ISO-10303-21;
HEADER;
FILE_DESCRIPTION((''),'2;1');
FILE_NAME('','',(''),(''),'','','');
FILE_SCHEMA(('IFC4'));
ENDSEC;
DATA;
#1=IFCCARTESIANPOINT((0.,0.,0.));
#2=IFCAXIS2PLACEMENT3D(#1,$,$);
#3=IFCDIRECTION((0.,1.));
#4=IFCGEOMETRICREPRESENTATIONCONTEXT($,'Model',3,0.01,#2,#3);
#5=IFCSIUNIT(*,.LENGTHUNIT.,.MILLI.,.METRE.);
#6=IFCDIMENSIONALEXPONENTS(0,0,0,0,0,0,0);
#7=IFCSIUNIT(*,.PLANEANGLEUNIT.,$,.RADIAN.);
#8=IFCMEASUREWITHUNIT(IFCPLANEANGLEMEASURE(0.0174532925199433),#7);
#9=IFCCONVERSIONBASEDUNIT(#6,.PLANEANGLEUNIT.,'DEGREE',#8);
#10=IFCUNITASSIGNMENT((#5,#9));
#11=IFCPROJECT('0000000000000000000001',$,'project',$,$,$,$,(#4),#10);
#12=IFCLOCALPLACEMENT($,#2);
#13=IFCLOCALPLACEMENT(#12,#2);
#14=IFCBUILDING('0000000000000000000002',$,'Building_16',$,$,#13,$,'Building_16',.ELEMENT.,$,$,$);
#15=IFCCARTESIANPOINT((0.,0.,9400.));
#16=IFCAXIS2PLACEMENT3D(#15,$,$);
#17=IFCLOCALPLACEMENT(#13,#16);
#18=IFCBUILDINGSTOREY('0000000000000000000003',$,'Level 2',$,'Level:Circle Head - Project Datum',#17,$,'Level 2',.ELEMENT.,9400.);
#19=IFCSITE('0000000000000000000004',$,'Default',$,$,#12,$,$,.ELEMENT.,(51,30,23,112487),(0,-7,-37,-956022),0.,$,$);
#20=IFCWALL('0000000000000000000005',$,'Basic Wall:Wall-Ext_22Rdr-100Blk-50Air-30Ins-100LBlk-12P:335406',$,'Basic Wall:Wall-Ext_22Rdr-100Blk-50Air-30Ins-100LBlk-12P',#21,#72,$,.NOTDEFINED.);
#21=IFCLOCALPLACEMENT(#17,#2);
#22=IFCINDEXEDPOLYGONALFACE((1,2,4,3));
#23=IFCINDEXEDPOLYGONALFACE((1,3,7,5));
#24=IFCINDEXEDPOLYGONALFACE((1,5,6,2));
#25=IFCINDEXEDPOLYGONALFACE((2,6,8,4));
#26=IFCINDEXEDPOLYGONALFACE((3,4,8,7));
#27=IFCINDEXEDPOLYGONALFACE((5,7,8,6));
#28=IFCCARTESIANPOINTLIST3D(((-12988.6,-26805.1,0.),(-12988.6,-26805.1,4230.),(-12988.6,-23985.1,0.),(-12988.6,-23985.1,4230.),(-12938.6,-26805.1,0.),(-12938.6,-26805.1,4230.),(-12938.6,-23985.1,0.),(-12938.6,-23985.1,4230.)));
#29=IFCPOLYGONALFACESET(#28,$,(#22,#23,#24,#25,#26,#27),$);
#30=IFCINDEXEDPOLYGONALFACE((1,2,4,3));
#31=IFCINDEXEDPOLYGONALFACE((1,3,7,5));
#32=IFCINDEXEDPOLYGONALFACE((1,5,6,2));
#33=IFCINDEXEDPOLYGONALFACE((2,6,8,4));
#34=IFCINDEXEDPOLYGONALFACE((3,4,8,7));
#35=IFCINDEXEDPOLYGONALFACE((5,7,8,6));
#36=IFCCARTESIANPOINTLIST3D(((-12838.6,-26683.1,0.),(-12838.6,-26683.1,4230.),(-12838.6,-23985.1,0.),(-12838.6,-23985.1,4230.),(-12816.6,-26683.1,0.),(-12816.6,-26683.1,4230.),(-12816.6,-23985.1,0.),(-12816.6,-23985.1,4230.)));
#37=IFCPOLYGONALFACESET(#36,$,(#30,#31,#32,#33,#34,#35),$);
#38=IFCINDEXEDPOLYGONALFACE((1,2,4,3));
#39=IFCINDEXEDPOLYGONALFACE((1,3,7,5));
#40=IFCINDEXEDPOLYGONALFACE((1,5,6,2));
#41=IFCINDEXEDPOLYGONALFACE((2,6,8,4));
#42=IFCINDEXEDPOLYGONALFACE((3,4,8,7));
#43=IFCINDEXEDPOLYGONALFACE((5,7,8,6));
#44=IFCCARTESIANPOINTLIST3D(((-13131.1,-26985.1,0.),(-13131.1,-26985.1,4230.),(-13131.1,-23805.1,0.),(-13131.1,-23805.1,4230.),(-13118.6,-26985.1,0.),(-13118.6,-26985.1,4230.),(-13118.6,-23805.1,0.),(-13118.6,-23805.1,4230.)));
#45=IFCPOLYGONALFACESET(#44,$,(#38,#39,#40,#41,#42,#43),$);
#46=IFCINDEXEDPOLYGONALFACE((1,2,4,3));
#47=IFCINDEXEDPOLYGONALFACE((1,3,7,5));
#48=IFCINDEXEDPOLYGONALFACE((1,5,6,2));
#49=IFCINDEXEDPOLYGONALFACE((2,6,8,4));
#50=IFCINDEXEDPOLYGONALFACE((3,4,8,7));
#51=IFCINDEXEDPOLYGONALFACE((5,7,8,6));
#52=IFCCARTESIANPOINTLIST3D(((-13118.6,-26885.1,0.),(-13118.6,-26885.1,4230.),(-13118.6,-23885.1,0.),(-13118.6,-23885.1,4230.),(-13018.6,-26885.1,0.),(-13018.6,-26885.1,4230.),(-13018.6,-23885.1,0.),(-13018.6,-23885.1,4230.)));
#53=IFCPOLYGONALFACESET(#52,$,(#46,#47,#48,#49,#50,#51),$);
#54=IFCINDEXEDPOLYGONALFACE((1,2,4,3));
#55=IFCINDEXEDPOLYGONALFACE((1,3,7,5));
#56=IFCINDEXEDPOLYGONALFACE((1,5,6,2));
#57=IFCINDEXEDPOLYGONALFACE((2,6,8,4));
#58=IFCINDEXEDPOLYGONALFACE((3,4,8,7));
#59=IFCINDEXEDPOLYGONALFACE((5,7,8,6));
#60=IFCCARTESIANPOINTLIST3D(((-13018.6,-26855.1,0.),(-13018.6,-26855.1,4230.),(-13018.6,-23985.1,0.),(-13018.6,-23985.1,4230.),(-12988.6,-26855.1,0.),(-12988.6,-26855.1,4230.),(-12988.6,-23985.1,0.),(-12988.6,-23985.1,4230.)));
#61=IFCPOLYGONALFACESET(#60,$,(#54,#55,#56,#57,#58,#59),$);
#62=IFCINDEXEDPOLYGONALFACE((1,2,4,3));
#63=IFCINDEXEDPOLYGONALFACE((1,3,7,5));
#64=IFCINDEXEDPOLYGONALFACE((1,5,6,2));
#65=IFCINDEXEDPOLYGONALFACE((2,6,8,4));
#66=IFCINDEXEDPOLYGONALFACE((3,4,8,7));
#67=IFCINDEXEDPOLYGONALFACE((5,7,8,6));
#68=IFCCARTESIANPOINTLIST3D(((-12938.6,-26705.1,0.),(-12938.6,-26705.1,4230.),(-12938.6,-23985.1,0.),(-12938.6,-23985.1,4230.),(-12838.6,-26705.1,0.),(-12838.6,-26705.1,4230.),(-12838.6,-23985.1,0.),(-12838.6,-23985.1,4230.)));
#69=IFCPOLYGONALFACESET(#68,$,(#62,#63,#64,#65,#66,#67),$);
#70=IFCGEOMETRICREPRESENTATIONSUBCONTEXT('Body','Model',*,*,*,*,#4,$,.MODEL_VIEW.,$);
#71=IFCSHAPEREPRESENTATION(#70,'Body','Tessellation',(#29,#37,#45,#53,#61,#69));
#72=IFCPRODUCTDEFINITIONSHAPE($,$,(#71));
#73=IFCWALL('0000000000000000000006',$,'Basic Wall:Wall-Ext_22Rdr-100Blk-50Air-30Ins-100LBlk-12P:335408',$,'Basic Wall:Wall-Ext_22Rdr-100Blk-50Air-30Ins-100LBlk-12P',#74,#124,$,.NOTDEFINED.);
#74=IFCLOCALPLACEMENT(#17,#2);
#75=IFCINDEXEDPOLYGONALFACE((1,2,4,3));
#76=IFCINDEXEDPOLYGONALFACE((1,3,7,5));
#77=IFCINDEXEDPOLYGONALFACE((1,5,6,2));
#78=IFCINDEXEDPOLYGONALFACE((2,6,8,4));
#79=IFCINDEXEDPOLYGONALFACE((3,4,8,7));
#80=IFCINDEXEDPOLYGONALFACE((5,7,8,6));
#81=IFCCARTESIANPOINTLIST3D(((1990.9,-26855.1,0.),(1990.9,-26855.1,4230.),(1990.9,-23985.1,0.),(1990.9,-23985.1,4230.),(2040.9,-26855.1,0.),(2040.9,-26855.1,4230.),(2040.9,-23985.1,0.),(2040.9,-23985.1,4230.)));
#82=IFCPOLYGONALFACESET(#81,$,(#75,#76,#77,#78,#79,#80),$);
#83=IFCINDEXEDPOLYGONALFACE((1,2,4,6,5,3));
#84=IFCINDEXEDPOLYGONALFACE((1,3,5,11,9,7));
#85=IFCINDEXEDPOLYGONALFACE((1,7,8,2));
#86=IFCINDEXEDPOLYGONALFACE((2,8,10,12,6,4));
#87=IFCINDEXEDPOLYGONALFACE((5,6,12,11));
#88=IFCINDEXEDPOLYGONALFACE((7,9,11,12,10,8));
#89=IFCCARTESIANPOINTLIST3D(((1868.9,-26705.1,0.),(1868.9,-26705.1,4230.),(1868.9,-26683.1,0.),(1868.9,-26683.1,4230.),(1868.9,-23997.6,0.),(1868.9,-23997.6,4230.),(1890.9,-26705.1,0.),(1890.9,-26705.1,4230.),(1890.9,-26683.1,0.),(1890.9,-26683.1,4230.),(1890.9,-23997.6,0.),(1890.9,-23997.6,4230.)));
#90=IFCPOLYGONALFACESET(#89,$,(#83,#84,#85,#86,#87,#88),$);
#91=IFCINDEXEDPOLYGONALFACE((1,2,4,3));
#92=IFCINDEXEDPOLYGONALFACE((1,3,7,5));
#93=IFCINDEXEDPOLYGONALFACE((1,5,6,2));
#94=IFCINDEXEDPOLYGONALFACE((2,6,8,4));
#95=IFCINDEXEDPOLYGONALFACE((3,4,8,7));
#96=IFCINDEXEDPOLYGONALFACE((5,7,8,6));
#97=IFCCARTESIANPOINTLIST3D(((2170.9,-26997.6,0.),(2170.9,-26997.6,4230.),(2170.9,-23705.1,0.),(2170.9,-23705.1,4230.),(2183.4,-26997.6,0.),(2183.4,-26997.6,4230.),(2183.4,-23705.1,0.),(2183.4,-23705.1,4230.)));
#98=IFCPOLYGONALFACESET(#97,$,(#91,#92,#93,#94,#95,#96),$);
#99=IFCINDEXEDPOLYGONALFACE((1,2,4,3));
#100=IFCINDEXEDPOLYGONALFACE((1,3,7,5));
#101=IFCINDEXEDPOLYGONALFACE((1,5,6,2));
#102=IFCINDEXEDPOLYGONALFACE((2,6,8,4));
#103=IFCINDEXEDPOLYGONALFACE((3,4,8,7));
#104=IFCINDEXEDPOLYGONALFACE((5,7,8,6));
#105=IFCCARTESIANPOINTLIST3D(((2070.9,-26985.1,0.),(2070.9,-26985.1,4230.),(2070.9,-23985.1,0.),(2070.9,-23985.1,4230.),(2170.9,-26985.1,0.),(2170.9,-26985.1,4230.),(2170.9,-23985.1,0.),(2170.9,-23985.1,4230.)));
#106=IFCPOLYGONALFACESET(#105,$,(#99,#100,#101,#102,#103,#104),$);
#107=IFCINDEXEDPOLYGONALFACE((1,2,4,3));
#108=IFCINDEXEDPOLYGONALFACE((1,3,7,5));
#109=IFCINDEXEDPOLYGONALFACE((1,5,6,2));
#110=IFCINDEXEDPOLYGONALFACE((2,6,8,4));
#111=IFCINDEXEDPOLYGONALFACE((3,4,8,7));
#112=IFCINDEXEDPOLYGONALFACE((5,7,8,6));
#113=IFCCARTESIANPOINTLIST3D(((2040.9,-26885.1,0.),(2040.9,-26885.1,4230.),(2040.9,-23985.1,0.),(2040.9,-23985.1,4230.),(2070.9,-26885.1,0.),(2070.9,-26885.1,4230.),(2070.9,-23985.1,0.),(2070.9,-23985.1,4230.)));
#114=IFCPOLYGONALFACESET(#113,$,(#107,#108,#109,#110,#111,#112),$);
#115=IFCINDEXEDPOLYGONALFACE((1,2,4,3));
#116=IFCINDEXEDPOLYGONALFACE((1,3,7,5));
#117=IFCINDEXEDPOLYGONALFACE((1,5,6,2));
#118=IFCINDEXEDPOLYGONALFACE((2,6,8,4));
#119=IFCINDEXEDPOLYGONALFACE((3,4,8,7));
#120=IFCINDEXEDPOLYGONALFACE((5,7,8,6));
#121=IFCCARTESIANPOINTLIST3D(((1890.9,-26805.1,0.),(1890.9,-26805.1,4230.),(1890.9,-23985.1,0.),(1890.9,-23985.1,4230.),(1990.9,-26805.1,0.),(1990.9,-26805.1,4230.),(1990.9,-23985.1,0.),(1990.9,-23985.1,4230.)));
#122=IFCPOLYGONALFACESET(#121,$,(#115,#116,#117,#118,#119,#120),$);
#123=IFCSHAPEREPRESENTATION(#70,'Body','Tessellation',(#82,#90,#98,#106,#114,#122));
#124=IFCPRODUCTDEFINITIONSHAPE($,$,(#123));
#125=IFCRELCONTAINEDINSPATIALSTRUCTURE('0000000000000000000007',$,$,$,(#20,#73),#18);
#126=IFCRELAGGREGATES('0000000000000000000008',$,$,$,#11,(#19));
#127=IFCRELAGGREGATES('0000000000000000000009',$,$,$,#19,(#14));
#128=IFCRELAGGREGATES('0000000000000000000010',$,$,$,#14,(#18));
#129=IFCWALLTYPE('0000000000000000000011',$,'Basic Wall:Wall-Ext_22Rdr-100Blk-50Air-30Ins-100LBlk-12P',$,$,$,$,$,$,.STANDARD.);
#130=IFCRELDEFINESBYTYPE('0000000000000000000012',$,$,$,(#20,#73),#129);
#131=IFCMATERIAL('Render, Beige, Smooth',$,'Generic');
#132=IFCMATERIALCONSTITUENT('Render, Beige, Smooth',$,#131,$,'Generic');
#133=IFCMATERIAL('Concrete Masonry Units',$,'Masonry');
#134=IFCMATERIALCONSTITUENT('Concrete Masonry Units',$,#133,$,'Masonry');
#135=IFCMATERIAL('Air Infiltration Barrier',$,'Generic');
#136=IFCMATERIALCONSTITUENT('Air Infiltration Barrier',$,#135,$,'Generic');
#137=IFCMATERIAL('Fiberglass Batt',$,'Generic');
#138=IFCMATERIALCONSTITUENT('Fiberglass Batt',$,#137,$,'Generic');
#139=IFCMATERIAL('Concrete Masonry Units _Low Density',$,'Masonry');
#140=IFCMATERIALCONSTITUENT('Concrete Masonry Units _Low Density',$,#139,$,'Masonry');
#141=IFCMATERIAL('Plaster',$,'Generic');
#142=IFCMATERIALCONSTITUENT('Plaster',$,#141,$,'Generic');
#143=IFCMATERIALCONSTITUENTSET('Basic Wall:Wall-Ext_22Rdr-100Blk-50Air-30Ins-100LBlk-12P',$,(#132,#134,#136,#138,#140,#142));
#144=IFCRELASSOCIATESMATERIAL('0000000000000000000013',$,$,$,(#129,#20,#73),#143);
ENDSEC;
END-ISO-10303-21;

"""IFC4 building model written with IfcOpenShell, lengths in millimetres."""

from ifc_helpers import new_model, entity, si_unit, converted_unit, direction, frame, origin, place, context, subcontext, project, spatial, indexed_curve, outline, extrude, material, constituent, constituent_set, type_object, element, save


model = new_model("IFC4")

# Units and contexts
model_context = context("Model", 3, precision=0.01, world=origin(), true_north=direction((0.0, 1.0)))
body_context = subcontext(model_context, "Body", "Model", "MODEL_VIEW")
ifc_project = project(units=[si_unit("LENGTHUNIT", "METRE", prefix="MILLI"), converted_unit("PLANEANGLEUNIT", "DEGREE", entity("IfcPlaneAngleMeasure", 0.0174532925199433), si_unit("PLANEANGLEUNIT", "RADIAN"), dimensions=[0, 0, 0, 0, 0, 0, 0])], contexts=[model_context])

# Site, building, storey
site_placement = place(None, origin())
site = spatial("IfcSite", under=ifc_project, at=site_placement, Name="Default", CompositionType="ELEMENT", RefLatitude=(51, 30, 23, 112487), RefLongitude=(0, -7, -37, -956022), RefElevation=0.0)
building_placement = place(site_placement, origin())
building = spatial("IfcBuilding", under=site, at=building_placement, Name="Building_16", LongName="Building_16", CompositionType="ELEMENT")
storey_placement = place(building_placement, frame((0.0, 0.0, 9400.0)))
storey = spatial("IfcBuildingStorey", under=building, at=storey_placement, Name="Level 2", ObjectType="Level:Circle Head - Project Datum", LongName="Level 2", CompositionType="ELEMENT", Elevation=9400.0)

# Shared definitions
ifc_material_1 = material(Name="Render, Beige, Smooth", Category="Generic")
ifc_constituent_1 = constituent(ifc_material_1, Name="Render, Beige, Smooth", Category="Generic")
ifc_material_2 = material(Name="Concrete Masonry Units", Category="Masonry")
ifc_constituent_2 = constituent(ifc_material_2, Name="Concrete Masonry Units", Category="Masonry")
ifc_material_3 = material(Name="Air Infiltration Barrier", Category="Generic")
ifc_constituent_3 = constituent(ifc_material_3, Name="Air Infiltration Barrier", Category="Generic")
ifc_material_4 = material(Name="Fiberglass Batt", Category="Generic")
ifc_constituent_4 = constituent(ifc_material_4, Name="Fiberglass Batt", Category="Generic")
ifc_material_5 = material(Name="Concrete Masonry Units _Low Density", Category="Masonry")
ifc_constituent_5 = constituent(ifc_material_5, Name="Concrete Masonry Units _Low Density", Category="Masonry")
ifc_material_6 = material(Name="Plaster", Category="Generic")
ifc_constituent_6 = constituent(ifc_material_6, Name="Plaster", Category="Generic")
ifc_constituent_set_1 = constituent_set(constituents=[ifc_constituent_1, ifc_constituent_2, ifc_constituent_3, ifc_constituent_4, ifc_constituent_5, ifc_constituent_6], Name="Basic Wall:Wall-Ext_22Rdr-100Blk-50Air-30Ins-100LBlk-12P")
wall_type_1 = type_object("IfcWallType", Name="Basic Wall:Wall-Ext_22Rdr-100Blk-50Air-30Ins-100LBlk-12P", PredefinedType="STANDARD", material=ifc_constituent_set_1)

# Wall
wall_1_placement = place(storey_placement, frame((-12973.9, -23683.1, 0.0), z_axis=(0.0, 0.0, 1.0), x_axis=(0.0, -1.0, 0.0)))
element("IfcWall", 1, at=wall_1_placement, inside=storey, type_object=wall_type_1, material=ifc_constituent_set_1, Name="Basic Wall:Wall-Ext_22Rdr-100Blk-50Air-30Ins-100LBlk-12P:335406", ObjectType="Basic Wall:Wall-Ext_22Rdr-100Blk-50Air-30Ins-100LBlk-12P", PredefinedType="NOTDEFINED", context=body_context, shape_type="SweptSolid", body=[
    extrude(outline(indexed_curve([(-2115.0, -1410.0), (2115.0, -1410.0), (2115.0, 1410.0), (-2115.0, 1410.0), (-2115.0, -1410.0)], self_intersect=False)), frame((1712.0, -14.8, 2115.0), z_axis=(0.0, 1.0, 0.0), x_axis=(0.0, 0.0, 1.0)), (0.0, 0.0, 1.0), 50.0),
    extrude(outline(indexed_curve([(-2115.0, -1349.0), (2115.0, -1349.0), (2115.0, 1349.0), (-2115.0, 1349.0), (-2115.0, -1349.0)], self_intersect=False)), frame((1651.0, 135.2, 2115.0), z_axis=(0.0, 1.0, 0.0), x_axis=(0.0, 0.0, 1.0)), (0.0, 0.0, 1.0), 22.0),
    extrude(outline(indexed_curve([(-2115.0, -1590.0), (2115.0, -1590.0), (2115.0, 1590.0), (-2115.0, 1590.0), (-2115.0, -1590.0)], self_intersect=False)), frame((1712.0, -157.2, 2115.0), z_axis=(0.0, 1.0, 0.0), x_axis=(0.0, 0.0, 1.0)), (0.0, 0.0, 1.0), 12.5),
    extrude(outline(indexed_curve([(-2115.0, -1500.0), (2115.0, -1500.0), (2115.0, 1500.0), (-2115.0, 1500.0), (-2115.0, -1500.0)], self_intersect=False)), frame((1702.0, -144.8, 2115.0), z_axis=(0.0, 1.0, 0.0), x_axis=(0.0, 0.0, 1.0)), (0.0, 0.0, 1.0), 100.0),
    extrude(outline(indexed_curve([(-2115.0, -1435.0), (2115.0, -1435.0), (2115.0, 1435.0), (-2115.0, 1435.0), (-2115.0, -1435.0)], self_intersect=False)), frame((1737.0, -44.8, 2115.0), z_axis=(0.0, 1.0, 0.0), x_axis=(0.0, 0.0, 1.0)), (0.0, 0.0, 1.0), 30.0),
    extrude(outline(indexed_curve([(-2115.0, -1360.0), (2115.0, -1360.0), (2115.0, 1360.0), (-2115.0, 1360.0), (-2115.0, -1360.0)], self_intersect=False)), frame((1662.0, 35.3, 2115.0), z_axis=(0.0, 1.0, 0.0), x_axis=(0.0, 0.0, 1.0)), (0.0, 0.0, 1.0), 100.0),
])

# Wall
wall_2_placement = place(storey_placement, frame((2026.1, -26997.6, 0.0), z_axis=(0.0, 0.0, 1.0), x_axis=(0.0, 1.0, 0.0)))
element("IfcWall", 2, at=wall_2_placement, inside=storey, type_object=wall_type_1, material=ifc_constituent_set_1, Name="Basic Wall:Wall-Ext_22Rdr-100Blk-50Air-30Ins-100LBlk-12P:335408", ObjectType="Basic Wall:Wall-Ext_22Rdr-100Blk-50Air-30Ins-100LBlk-12P", PredefinedType="NOTDEFINED", context=body_context, shape_type="SweptSolid", body=[
    extrude(outline(indexed_curve([(-2115.0, -1435.0), (2115.0, -1435.0), (2115.0, 1435.0), (-2115.0, 1435.0), (-2115.0, -1435.0)], self_intersect=False)), frame((1577.5, 35.3, 2115.0), z_axis=(0.0, -1.0, 0.0), x_axis=(0.0, 0.0, 1.0)), (0.0, 0.0, 1.0), 50.0),
    extrude(outline(indexed_curve([(-909.8, -2115.0), (-887.8, -2115.0), (1797.7, -2115.0), (1797.7, 2115.0), (-887.8, 2115.0), (-909.8, 2115.0), (-909.8, -2115.0)], self_intersect=False)), frame((1202.3, 157.2, 2115.0), z_axis=(0.0, -1.0, 0.0), x_axis=(1.0, 0.0, 0.0)), (0.0, 0.0, 1.0), 22.0),
    extrude(outline(indexed_curve([(-2115.0, -1646.2), (2115.0, -1646.2), (2115.0, 1646.2), (-2115.0, 1646.2), (-2115.0, -1646.2)], self_intersect=False)), frame((1646.2, -144.8, 2115.0), z_axis=(0.0, -1.0, 0.0), x_axis=(0.0, 0.0, 1.0)), (0.0, 0.0, 1.0), 12.5),
    extrude(outline(indexed_curve([(-2115.0, -1500.0), (2115.0, -1500.0), (2115.0, 1500.0), (-2115.0, 1500.0), (-2115.0, -1500.0)], self_intersect=False)), frame((1512.5, -44.8, 2115.0), z_axis=(0.0, -1.0, 0.0), x_axis=(0.0, 0.0, 1.0)), (0.0, 0.0, 1.0), 100.0),
    extrude(outline(indexed_curve([(-2115.0, -1450.0), (2115.0, -1450.0), (2115.0, 1450.0), (-2115.0, 1450.0), (-2115.0, -1450.0)], self_intersect=False)), frame((1562.5, -14.7, 2115.0), z_axis=(0.0, -1.0, 0.0), x_axis=(0.0, 0.0, 1.0)), (0.0, 0.0, 1.0), 30.0),
    extrude(outline(indexed_curve([(-2115.0, -1410.0), (2115.0, -1410.0), (2115.0, 1410.0), (-2115.0, 1410.0), (-2115.0, -1410.0)], self_intersect=False)), frame((1602.5, 135.2, 2115.0), z_axis=(0.0, -1.0, 0.0), x_axis=(0.0, 0.0, 1.0)), (0.0, 0.0, 1.0), 100.0),
])

save(model, "model.ifc")
